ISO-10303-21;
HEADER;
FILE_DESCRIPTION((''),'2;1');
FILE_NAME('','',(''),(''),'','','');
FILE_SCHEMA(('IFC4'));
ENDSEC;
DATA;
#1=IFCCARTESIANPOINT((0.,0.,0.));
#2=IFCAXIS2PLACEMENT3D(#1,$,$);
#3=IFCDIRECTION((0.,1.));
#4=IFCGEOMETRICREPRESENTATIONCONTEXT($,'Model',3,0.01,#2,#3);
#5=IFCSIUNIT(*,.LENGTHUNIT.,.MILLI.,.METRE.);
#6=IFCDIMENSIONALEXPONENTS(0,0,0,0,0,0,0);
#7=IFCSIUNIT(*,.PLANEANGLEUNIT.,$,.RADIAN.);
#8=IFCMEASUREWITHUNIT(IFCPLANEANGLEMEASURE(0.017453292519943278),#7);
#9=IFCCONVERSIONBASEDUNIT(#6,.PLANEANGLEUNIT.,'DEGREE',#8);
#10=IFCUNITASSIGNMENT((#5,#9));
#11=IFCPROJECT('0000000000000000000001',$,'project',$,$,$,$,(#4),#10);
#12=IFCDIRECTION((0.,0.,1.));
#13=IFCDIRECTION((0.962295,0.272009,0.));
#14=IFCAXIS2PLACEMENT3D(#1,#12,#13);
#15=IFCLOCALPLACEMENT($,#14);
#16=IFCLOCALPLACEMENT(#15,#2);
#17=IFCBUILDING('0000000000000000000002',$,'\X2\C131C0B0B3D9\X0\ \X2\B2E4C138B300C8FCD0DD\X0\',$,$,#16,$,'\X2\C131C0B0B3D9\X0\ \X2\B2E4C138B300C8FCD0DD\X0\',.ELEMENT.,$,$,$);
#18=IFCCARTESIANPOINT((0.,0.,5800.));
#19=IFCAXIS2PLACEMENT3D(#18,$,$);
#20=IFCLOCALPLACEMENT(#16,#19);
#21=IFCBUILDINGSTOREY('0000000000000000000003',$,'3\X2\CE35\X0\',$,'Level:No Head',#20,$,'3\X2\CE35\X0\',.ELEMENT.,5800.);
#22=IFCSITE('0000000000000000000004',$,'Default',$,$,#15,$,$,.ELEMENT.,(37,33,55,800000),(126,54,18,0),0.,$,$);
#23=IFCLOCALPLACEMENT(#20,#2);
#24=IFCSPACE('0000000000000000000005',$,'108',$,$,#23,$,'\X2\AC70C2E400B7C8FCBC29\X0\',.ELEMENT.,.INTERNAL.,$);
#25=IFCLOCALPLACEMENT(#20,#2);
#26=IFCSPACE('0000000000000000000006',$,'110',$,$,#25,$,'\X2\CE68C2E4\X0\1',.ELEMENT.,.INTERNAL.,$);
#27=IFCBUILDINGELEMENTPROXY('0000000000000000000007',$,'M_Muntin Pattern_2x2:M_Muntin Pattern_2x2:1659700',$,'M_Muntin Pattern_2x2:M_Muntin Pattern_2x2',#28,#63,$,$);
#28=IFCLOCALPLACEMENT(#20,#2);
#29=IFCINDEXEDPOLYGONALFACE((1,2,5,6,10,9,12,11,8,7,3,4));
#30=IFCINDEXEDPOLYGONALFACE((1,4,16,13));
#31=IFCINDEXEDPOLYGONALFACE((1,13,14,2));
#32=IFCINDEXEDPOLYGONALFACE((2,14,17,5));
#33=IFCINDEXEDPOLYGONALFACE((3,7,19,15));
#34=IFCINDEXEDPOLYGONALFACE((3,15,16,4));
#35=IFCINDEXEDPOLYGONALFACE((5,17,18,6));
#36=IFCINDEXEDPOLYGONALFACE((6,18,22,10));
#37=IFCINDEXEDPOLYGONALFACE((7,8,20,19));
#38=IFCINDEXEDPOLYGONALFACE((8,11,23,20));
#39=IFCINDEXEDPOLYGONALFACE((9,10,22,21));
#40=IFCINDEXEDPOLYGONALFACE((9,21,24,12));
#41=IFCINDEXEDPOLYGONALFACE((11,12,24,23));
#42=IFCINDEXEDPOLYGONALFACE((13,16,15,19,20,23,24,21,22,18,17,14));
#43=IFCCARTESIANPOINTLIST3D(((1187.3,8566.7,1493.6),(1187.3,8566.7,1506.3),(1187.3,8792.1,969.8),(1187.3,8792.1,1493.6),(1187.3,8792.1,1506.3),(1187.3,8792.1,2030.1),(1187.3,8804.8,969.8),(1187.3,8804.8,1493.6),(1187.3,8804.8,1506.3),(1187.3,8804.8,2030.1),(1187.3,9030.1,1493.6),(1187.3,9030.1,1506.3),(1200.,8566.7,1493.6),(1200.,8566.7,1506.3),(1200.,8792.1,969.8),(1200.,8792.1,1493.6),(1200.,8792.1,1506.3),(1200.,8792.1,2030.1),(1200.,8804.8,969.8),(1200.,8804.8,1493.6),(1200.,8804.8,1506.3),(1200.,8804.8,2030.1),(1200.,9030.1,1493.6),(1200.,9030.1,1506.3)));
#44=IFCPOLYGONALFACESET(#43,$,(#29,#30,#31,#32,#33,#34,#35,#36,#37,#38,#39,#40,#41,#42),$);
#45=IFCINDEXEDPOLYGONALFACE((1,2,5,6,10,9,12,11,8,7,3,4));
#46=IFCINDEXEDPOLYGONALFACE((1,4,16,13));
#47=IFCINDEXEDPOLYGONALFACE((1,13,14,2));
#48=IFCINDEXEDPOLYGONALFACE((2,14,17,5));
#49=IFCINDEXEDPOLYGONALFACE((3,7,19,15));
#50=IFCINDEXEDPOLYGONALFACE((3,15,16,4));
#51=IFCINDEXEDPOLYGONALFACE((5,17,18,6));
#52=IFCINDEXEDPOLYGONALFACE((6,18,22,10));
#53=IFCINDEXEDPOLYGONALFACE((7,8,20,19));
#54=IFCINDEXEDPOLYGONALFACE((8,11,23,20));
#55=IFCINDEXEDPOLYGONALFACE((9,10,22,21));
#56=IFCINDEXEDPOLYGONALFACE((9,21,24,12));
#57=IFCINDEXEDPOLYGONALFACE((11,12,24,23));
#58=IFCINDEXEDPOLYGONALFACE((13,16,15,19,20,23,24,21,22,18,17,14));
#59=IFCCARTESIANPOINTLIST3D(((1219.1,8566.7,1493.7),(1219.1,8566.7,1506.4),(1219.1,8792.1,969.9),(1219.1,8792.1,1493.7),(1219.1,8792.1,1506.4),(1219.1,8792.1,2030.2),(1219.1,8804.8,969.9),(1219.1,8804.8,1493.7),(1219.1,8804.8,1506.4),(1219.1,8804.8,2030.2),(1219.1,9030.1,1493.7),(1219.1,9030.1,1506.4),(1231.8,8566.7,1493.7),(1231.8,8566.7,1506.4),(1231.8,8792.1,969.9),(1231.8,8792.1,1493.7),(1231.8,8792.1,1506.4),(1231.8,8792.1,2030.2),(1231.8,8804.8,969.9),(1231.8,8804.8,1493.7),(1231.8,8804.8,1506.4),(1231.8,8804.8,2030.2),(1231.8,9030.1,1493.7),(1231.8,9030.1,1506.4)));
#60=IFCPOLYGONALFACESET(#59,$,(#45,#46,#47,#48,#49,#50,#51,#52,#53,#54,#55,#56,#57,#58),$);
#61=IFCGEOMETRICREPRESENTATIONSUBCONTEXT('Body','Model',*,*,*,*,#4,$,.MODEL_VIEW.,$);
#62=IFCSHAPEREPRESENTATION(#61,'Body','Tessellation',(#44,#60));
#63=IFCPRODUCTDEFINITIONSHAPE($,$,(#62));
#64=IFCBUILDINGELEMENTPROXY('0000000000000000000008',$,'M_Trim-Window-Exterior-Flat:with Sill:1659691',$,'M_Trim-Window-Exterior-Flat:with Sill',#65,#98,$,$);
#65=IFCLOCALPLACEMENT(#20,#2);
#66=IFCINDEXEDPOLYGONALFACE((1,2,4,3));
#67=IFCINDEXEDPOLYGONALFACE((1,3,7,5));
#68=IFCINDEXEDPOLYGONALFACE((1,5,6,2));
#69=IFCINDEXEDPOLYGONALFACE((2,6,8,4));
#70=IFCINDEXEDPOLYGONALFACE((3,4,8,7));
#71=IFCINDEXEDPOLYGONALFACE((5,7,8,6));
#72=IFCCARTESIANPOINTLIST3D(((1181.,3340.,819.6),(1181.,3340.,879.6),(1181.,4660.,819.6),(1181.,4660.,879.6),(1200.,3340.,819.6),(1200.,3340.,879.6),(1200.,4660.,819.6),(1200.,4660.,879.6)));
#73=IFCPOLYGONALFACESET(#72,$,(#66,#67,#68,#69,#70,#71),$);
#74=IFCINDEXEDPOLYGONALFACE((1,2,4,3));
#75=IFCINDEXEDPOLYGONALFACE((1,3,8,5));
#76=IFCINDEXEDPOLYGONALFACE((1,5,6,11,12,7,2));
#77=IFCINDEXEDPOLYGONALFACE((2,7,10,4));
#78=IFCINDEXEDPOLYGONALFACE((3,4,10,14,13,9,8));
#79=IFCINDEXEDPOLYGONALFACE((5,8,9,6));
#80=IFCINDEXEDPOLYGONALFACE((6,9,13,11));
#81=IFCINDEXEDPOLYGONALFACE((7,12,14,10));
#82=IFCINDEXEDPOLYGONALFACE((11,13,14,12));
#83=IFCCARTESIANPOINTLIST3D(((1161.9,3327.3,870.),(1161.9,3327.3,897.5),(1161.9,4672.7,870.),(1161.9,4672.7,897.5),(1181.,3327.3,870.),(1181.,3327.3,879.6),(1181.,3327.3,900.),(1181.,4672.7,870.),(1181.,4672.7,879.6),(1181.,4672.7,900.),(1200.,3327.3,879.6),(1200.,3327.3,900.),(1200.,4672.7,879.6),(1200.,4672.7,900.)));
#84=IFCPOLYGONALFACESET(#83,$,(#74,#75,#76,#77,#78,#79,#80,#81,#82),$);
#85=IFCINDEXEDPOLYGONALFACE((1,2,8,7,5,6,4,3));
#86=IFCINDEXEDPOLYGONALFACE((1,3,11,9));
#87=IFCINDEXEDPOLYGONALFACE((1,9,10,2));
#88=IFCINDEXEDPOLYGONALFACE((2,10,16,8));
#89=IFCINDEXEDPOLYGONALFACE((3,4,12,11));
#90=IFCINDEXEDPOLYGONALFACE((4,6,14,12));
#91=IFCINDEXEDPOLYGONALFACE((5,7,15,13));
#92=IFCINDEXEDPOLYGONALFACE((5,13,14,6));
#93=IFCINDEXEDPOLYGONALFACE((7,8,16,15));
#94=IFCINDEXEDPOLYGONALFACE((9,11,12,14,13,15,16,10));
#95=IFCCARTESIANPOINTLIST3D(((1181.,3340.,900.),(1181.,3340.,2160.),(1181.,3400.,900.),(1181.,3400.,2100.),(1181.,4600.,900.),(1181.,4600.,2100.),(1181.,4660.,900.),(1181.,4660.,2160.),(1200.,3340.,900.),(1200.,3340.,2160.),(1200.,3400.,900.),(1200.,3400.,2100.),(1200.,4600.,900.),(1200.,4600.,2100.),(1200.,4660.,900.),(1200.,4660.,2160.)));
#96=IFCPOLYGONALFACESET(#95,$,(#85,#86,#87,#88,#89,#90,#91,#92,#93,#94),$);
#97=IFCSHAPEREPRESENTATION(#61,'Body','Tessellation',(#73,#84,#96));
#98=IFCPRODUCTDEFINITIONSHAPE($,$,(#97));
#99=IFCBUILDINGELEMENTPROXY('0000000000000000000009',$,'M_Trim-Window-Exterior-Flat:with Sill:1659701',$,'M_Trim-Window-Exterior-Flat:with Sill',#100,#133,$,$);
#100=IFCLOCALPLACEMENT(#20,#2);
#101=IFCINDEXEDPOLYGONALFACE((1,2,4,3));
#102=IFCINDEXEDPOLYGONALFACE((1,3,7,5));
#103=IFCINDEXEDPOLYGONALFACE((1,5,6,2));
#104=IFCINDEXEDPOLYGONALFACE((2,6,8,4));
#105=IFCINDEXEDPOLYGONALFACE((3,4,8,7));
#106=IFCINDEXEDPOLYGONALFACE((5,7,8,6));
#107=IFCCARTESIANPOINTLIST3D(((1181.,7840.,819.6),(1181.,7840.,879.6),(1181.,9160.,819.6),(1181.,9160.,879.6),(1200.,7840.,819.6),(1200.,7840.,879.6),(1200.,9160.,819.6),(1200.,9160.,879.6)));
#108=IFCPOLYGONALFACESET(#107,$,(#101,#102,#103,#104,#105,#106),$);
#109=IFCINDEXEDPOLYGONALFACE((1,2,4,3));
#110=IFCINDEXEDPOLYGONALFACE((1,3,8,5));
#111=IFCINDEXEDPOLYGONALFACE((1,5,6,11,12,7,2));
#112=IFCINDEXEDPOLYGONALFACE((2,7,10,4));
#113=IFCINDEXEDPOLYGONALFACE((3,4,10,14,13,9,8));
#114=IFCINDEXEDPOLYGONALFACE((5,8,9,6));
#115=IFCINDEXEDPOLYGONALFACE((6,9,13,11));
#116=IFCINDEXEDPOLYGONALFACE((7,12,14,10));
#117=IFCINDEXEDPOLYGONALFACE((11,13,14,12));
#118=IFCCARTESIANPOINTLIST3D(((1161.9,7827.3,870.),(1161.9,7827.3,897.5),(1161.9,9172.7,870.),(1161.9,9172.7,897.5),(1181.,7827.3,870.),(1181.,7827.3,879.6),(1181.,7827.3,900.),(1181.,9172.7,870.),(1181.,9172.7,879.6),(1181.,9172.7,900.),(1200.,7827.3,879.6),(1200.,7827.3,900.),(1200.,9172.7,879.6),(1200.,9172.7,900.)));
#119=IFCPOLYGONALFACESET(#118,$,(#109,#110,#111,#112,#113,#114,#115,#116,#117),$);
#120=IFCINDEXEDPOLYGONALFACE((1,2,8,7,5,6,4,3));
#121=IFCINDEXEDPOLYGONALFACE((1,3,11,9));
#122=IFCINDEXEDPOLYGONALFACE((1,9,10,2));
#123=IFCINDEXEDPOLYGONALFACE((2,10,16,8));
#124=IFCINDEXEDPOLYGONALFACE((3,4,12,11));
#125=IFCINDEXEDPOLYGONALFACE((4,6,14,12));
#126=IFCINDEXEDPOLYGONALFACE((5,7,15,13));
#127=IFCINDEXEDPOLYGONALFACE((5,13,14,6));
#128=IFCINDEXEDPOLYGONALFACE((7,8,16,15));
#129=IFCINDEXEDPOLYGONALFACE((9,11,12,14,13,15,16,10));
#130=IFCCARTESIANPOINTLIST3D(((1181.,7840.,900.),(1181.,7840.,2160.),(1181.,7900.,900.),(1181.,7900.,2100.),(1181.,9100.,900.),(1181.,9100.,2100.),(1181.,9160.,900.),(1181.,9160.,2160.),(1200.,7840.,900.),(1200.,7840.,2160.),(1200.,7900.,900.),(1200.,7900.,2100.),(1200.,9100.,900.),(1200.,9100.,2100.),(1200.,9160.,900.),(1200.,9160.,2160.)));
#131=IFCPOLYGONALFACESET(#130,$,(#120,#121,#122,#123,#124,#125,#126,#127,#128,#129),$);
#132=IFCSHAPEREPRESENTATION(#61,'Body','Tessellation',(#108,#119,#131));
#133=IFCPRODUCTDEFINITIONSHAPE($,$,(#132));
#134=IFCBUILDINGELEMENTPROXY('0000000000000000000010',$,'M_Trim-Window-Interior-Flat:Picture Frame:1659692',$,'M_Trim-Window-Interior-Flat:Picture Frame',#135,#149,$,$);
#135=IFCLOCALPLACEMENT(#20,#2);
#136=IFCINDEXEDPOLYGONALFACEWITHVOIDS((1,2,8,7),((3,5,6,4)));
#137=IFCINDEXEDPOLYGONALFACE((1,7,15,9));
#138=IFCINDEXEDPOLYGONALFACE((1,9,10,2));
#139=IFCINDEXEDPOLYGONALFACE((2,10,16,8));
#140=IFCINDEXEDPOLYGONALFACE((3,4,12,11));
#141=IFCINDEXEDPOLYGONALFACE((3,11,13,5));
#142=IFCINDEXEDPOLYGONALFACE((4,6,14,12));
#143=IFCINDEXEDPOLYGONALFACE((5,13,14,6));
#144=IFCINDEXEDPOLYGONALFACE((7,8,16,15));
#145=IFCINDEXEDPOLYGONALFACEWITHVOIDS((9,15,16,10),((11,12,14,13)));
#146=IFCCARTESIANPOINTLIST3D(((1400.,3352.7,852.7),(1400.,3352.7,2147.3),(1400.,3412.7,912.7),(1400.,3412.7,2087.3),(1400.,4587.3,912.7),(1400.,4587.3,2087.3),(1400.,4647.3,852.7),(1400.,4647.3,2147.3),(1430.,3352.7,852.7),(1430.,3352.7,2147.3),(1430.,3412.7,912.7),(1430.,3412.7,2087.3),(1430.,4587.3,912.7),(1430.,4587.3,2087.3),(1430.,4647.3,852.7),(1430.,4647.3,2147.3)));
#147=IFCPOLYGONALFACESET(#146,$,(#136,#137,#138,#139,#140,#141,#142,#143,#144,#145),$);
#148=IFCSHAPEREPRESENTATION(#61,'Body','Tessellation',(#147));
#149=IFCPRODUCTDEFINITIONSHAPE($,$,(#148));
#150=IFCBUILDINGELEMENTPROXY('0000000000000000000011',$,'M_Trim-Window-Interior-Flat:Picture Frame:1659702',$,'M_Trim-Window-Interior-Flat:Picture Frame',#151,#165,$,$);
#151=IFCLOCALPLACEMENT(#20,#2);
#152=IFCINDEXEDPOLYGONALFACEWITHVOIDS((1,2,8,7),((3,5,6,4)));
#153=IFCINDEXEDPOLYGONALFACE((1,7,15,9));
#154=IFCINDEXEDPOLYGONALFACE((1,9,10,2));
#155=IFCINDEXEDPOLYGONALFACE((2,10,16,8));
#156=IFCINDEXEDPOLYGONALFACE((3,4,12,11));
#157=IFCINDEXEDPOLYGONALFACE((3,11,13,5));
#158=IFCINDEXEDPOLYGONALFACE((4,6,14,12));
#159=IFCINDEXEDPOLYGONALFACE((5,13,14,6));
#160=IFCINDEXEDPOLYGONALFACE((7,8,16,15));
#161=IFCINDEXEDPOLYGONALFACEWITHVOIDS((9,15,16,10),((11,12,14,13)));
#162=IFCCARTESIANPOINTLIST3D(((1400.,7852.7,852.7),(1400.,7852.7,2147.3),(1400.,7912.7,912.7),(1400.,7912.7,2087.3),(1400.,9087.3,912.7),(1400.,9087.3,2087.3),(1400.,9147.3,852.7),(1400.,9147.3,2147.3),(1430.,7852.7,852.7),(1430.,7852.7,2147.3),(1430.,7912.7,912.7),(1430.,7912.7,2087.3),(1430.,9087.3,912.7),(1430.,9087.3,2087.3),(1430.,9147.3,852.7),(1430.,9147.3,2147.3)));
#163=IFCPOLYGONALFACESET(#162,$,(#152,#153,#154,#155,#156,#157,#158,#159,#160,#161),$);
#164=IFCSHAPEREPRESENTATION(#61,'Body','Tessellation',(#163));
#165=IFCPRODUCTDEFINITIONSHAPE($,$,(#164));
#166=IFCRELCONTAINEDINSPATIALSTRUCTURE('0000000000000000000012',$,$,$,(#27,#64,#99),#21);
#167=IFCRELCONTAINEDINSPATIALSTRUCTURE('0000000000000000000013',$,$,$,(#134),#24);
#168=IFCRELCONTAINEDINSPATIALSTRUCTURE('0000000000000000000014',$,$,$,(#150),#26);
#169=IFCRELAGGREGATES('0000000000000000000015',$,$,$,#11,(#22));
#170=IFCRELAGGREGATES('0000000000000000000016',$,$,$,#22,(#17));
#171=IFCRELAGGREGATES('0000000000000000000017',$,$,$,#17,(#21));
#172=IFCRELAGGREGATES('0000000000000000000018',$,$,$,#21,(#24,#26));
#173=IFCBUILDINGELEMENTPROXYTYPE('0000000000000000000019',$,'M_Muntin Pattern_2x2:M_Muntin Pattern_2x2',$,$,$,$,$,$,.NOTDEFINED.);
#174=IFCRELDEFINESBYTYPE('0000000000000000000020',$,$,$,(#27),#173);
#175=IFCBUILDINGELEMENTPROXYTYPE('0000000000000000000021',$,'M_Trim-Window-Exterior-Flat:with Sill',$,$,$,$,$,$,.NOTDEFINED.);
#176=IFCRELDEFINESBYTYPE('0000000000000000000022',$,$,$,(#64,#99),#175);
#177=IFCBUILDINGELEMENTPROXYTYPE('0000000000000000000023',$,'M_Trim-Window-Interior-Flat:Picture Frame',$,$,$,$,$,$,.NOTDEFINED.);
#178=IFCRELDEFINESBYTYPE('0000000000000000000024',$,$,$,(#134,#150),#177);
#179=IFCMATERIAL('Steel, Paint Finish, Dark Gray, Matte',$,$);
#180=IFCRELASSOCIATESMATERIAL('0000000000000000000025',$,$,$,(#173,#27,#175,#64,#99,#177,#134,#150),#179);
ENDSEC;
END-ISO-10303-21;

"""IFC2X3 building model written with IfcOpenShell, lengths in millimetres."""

from ifc_helpers import new_model, entity, si_unit, converted_unit, direction, frame, frame_2d, origin, place, context, subcontext, project, spatial, polyline, rectangle, outline, extrude, source, transform, mapped, material, type_object, type_shapes, element, save


model = new_model("IFC2X3")

# Units and contexts
model_context = context("Model", 3, precision=0.01, world=origin(), true_north=direction((0.0, 1.0)))
body_context = subcontext(model_context, "Body", "Model", "MODEL_VIEW")
ifc_project = project(units=[si_unit("LENGTHUNIT", "METRE", prefix="MILLI"), converted_unit("PLANEANGLEUNIT", "DEGREE", entity("IfcPlaneAngleMeasure", 0.017453292519943278), si_unit("PLANEANGLEUNIT", "RADIAN"), dimensions=[0, 0, 0, 0, 0, 0, 0])], contexts=[model_context])

# Site, building, storey
site_placement = place(None, frame((0.0, 0.0, 0.0), z_axis=(0.0, 0.0, 1.0), x_axis=(0.962295, 0.272009, 0.0)))
site = spatial("IfcSite", under=ifc_project, at=site_placement, Name="Default", CompositionType="ELEMENT", RefLatitude=(37, 33, 55, 800000), RefLongitude=(126, 54, 18, 0), RefElevation=0.0)
building_placement = place(site_placement, origin())
building = spatial("IfcBuilding", under=site, at=building_placement, Name="성산동 다세대주택", LongName="성산동 다세대주택", CompositionType="ELEMENT")
storey_placement = place(building_placement, frame((0.0, 0.0, 5800.0)))
storey = spatial("IfcBuildingStorey", under=building, at=storey_placement, Name="3층", ObjectType="Level:No Head", LongName="3층", CompositionType="ELEMENT", Elevation=5800.0)

# Shared definitions
space_1_placement = place(storey_placement, origin())
space_1 = spatial("IfcSpace", under=storey, at=space_1_placement, Name="108", LongName="거실·주방", CompositionType="ELEMENT", InteriorOrExteriorSpace="INTERNAL")

# Shared definitions
space_2_placement = place(storey_placement, origin())
space_2 = spatial("IfcSpace", under=storey, at=space_2_placement, Name="110", LongName="침실1", CompositionType="ELEMENT", InteriorOrExteriorSpace="INTERNAL")

# Building element proxies
ifc_material_1 = material(Name="Steel, Paint Finish, Dark Gray, Matte")
building_element_proxy_type_1 = type_object("IfcBuildingElementProxyType", Name="M_Muntin Pattern_2x2:M_Muntin Pattern_2x2", PredefinedType="NOTDEFINED", material=ifc_material_1)
shared_shape_1 = source(origin(), body_context, "Body", "SweptSolid", [
    extrude(outline(polyline([(6.4, -6.4), (530.1, -6.4), (530.1, 6.3), (6.4, 6.3), (6.4, 231.7), (-6.3, 231.7), (-6.3, 6.3), (-530.2, 6.3), (-530.2, -6.4), (-6.3, -6.4), (-6.3, -231.7), (6.4, -231.7), (6.4, -6.4)])), frame((0.0, -22.2, 530.1), z_axis=(0.0, 1.0, 0.0), x_axis=(0.0, 0.0, 1.0)), (0.0, 0.0, 1.0), 12.7),
    extrude(outline(polyline([(6.4, -6.4), (530.2, -6.4), (530.2, 6.3), (6.4, 6.3), (6.4, 231.7), (-6.3, 231.7), (-6.3, 6.3), (-530.2, 6.3), (-530.2, -6.4), (-6.3, -6.4), (-6.3, -231.7), (6.4, -231.7), (6.4, -6.4)])), frame((0.0, 9.5, 530.2), z_axis=(0.0, 1.0, 0.0), x_axis=(0.0, 0.0, 1.0)), (0.0, 0.0, 1.0), 12.7),
])
type_shapes(building_element_proxy_type_1, [shared_shape_1])
for number, where, z_axis, x_axis, name in (
    (1, (1209.5, 8798.4, 969.9), (0.0, 0.0, 1.0), (0.0, -1.0, 0.0), "M_Muntin Pattern_2x2:M_Muntin Pattern_2x2:1659700"),
):
    element("IfcBuildingElementProxy", number, at=place(storey_placement, frame(where, z_axis=z_axis, x_axis=x_axis)), inside=storey, type_object=building_element_proxy_type_1, material=ifc_material_1, Name=name, ObjectType="M_Muntin Pattern_2x2:M_Muntin Pattern_2x2", context=body_context, shape_type="MappedRepresentation", body=[
        mapped(shared_shape_1, transform((0.0, 0.0, 0.0), scale=1.0)),
    ])
building_element_proxy_type_2 = type_object("IfcBuildingElementProxyType", Name="M_Trim-Window-Exterior-Flat:with Sill", PredefinedType="NOTDEFINED", material=ifc_material_1)
shared_shape_2 = source(origin(), body_context, "Body", "SweptSolid", [
    extrude(rectangle(XDim=1320.0, YDim=60.0, at=frame_2d((0.0, 0.0), x_axis=(1.0, 0.0))), frame((0.0, -1250.4, 0.0), z_axis=(0.0, 0.0, 1.0), x_axis=(-1.0, 0.0, 0.0)), (0.0, 0.0, 1.0), 19.0),
    extrude(outline(polyline([(-19.0, -15.2), (0.0, -15.2), (0.0, -5.7), (19.0, -5.7), (19.0, 14.8), (0.0, 14.8), (-19.0, 12.3), (-19.0, -15.2)])), frame((-672.7, -1214.8, 19.0), z_axis=(1.0, 0.0, 0.0), x_axis=(0.0, 0.0, -1.0)), (0.0, 0.0, 1.0), 1345.4),
    extrude(outline(polyline([(-645.0, -660.0), (615.0, -660.0), (615.0, -600.0), (-585.0, -600.0), (-585.0, 600.0), (615.0, 600.0), (615.0, 660.0), (-645.0, 660.0), (-645.0, -660.0)])), frame((0.0, -585.0, 0.0), z_axis=(0.0, 0.0, 1.0), x_axis=(0.0, -1.0, 0.0)), (0.0, 0.0, 1.0), 19.0),
])
type_shapes(building_element_proxy_type_2, [shared_shape_2])
for number, where, z_axis, x_axis, name in (
    (2, (1200.0, 4000.0, 2100.0), (-1.0, 0.0, 0.0), (0.0, -1.0, 0.0), "M_Trim-Window-Exterior-Flat:with Sill:1659691"),
    (3, (1200.0, 8500.0, 2100.0), (-1.0, 0.0, 0.0), (0.0, -1.0, 0.0), "M_Trim-Window-Exterior-Flat:with Sill:1659701"),
):
    element("IfcBuildingElementProxy", number, at=place(storey_placement, frame(where, z_axis=z_axis, x_axis=x_axis)), inside=storey, type_object=building_element_proxy_type_2, material=ifc_material_1, Name=name, ObjectType="M_Trim-Window-Exterior-Flat:with Sill", context=body_context, shape_type="MappedRepresentation", body=[
        mapped(shared_shape_2, transform((0.0, 0.0, 0.0), scale=1.0)),
    ])
building_element_proxy_type_3 = type_object("IfcBuildingElementProxyType", Name="M_Trim-Window-Interior-Flat:Picture Frame", PredefinedType="NOTDEFINED", material=ifc_material_1)
shared_shape_3 = source(origin(), body_context, "Body", "SweptSolid", [
    extrude(outline(polyline([(-647.3, -647.3), (647.3, -647.3), (647.3, 647.3), (-647.3, 647.3), (-647.3, -647.3)]), holes=[polyline([(-587.3, -587.3), (-587.3, 587.3), (587.3, 587.3), (587.3, -587.3), (-587.3, -587.3)])]), frame((0.0, -600.0, 0.0), z_axis=(0.0, 0.0, 1.0), x_axis=(-1.0, 0.0, 0.0)), (0.0, 0.0, 1.0), 30.0),
])
type_shapes(building_element_proxy_type_3, [shared_shape_3])
proxy_1_placement = place(space_1_placement, frame((1400.0, 4000.0, 2100.0), z_axis=(1.0, 0.0, 0.0), x_axis=(0.0, 1.0, 0.0)))
element("IfcBuildingElementProxy", 4, at=proxy_1_placement, inside=space_1, type_object=building_element_proxy_type_3, material=ifc_material_1, Name="M_Trim-Window-Interior-Flat:Picture Frame:1659692", ObjectType="M_Trim-Window-Interior-Flat:Picture Frame", context=body_context, shape_type="MappedRepresentation", body=[
    mapped(shared_shape_3, transform((0.0, 0.0, 0.0), scale=1.0)),
])
proxy_2_placement = place(space_2_placement, frame((1400.0, 8500.0, 2100.0), z_axis=(1.0, 0.0, 0.0), x_axis=(0.0, 1.0, 0.0)))
element("IfcBuildingElementProxy", 5, at=proxy_2_placement, inside=space_2, type_object=building_element_proxy_type_3, material=ifc_material_1, Name="M_Trim-Window-Interior-Flat:Picture Frame:1659702", ObjectType="M_Trim-Window-Interior-Flat:Picture Frame", context=body_context, shape_type="MappedRepresentation", body=[
    mapped(shared_shape_3, transform((0.0, 0.0, 0.0), scale=1.0)),
])

save(model, "model.ifc")
